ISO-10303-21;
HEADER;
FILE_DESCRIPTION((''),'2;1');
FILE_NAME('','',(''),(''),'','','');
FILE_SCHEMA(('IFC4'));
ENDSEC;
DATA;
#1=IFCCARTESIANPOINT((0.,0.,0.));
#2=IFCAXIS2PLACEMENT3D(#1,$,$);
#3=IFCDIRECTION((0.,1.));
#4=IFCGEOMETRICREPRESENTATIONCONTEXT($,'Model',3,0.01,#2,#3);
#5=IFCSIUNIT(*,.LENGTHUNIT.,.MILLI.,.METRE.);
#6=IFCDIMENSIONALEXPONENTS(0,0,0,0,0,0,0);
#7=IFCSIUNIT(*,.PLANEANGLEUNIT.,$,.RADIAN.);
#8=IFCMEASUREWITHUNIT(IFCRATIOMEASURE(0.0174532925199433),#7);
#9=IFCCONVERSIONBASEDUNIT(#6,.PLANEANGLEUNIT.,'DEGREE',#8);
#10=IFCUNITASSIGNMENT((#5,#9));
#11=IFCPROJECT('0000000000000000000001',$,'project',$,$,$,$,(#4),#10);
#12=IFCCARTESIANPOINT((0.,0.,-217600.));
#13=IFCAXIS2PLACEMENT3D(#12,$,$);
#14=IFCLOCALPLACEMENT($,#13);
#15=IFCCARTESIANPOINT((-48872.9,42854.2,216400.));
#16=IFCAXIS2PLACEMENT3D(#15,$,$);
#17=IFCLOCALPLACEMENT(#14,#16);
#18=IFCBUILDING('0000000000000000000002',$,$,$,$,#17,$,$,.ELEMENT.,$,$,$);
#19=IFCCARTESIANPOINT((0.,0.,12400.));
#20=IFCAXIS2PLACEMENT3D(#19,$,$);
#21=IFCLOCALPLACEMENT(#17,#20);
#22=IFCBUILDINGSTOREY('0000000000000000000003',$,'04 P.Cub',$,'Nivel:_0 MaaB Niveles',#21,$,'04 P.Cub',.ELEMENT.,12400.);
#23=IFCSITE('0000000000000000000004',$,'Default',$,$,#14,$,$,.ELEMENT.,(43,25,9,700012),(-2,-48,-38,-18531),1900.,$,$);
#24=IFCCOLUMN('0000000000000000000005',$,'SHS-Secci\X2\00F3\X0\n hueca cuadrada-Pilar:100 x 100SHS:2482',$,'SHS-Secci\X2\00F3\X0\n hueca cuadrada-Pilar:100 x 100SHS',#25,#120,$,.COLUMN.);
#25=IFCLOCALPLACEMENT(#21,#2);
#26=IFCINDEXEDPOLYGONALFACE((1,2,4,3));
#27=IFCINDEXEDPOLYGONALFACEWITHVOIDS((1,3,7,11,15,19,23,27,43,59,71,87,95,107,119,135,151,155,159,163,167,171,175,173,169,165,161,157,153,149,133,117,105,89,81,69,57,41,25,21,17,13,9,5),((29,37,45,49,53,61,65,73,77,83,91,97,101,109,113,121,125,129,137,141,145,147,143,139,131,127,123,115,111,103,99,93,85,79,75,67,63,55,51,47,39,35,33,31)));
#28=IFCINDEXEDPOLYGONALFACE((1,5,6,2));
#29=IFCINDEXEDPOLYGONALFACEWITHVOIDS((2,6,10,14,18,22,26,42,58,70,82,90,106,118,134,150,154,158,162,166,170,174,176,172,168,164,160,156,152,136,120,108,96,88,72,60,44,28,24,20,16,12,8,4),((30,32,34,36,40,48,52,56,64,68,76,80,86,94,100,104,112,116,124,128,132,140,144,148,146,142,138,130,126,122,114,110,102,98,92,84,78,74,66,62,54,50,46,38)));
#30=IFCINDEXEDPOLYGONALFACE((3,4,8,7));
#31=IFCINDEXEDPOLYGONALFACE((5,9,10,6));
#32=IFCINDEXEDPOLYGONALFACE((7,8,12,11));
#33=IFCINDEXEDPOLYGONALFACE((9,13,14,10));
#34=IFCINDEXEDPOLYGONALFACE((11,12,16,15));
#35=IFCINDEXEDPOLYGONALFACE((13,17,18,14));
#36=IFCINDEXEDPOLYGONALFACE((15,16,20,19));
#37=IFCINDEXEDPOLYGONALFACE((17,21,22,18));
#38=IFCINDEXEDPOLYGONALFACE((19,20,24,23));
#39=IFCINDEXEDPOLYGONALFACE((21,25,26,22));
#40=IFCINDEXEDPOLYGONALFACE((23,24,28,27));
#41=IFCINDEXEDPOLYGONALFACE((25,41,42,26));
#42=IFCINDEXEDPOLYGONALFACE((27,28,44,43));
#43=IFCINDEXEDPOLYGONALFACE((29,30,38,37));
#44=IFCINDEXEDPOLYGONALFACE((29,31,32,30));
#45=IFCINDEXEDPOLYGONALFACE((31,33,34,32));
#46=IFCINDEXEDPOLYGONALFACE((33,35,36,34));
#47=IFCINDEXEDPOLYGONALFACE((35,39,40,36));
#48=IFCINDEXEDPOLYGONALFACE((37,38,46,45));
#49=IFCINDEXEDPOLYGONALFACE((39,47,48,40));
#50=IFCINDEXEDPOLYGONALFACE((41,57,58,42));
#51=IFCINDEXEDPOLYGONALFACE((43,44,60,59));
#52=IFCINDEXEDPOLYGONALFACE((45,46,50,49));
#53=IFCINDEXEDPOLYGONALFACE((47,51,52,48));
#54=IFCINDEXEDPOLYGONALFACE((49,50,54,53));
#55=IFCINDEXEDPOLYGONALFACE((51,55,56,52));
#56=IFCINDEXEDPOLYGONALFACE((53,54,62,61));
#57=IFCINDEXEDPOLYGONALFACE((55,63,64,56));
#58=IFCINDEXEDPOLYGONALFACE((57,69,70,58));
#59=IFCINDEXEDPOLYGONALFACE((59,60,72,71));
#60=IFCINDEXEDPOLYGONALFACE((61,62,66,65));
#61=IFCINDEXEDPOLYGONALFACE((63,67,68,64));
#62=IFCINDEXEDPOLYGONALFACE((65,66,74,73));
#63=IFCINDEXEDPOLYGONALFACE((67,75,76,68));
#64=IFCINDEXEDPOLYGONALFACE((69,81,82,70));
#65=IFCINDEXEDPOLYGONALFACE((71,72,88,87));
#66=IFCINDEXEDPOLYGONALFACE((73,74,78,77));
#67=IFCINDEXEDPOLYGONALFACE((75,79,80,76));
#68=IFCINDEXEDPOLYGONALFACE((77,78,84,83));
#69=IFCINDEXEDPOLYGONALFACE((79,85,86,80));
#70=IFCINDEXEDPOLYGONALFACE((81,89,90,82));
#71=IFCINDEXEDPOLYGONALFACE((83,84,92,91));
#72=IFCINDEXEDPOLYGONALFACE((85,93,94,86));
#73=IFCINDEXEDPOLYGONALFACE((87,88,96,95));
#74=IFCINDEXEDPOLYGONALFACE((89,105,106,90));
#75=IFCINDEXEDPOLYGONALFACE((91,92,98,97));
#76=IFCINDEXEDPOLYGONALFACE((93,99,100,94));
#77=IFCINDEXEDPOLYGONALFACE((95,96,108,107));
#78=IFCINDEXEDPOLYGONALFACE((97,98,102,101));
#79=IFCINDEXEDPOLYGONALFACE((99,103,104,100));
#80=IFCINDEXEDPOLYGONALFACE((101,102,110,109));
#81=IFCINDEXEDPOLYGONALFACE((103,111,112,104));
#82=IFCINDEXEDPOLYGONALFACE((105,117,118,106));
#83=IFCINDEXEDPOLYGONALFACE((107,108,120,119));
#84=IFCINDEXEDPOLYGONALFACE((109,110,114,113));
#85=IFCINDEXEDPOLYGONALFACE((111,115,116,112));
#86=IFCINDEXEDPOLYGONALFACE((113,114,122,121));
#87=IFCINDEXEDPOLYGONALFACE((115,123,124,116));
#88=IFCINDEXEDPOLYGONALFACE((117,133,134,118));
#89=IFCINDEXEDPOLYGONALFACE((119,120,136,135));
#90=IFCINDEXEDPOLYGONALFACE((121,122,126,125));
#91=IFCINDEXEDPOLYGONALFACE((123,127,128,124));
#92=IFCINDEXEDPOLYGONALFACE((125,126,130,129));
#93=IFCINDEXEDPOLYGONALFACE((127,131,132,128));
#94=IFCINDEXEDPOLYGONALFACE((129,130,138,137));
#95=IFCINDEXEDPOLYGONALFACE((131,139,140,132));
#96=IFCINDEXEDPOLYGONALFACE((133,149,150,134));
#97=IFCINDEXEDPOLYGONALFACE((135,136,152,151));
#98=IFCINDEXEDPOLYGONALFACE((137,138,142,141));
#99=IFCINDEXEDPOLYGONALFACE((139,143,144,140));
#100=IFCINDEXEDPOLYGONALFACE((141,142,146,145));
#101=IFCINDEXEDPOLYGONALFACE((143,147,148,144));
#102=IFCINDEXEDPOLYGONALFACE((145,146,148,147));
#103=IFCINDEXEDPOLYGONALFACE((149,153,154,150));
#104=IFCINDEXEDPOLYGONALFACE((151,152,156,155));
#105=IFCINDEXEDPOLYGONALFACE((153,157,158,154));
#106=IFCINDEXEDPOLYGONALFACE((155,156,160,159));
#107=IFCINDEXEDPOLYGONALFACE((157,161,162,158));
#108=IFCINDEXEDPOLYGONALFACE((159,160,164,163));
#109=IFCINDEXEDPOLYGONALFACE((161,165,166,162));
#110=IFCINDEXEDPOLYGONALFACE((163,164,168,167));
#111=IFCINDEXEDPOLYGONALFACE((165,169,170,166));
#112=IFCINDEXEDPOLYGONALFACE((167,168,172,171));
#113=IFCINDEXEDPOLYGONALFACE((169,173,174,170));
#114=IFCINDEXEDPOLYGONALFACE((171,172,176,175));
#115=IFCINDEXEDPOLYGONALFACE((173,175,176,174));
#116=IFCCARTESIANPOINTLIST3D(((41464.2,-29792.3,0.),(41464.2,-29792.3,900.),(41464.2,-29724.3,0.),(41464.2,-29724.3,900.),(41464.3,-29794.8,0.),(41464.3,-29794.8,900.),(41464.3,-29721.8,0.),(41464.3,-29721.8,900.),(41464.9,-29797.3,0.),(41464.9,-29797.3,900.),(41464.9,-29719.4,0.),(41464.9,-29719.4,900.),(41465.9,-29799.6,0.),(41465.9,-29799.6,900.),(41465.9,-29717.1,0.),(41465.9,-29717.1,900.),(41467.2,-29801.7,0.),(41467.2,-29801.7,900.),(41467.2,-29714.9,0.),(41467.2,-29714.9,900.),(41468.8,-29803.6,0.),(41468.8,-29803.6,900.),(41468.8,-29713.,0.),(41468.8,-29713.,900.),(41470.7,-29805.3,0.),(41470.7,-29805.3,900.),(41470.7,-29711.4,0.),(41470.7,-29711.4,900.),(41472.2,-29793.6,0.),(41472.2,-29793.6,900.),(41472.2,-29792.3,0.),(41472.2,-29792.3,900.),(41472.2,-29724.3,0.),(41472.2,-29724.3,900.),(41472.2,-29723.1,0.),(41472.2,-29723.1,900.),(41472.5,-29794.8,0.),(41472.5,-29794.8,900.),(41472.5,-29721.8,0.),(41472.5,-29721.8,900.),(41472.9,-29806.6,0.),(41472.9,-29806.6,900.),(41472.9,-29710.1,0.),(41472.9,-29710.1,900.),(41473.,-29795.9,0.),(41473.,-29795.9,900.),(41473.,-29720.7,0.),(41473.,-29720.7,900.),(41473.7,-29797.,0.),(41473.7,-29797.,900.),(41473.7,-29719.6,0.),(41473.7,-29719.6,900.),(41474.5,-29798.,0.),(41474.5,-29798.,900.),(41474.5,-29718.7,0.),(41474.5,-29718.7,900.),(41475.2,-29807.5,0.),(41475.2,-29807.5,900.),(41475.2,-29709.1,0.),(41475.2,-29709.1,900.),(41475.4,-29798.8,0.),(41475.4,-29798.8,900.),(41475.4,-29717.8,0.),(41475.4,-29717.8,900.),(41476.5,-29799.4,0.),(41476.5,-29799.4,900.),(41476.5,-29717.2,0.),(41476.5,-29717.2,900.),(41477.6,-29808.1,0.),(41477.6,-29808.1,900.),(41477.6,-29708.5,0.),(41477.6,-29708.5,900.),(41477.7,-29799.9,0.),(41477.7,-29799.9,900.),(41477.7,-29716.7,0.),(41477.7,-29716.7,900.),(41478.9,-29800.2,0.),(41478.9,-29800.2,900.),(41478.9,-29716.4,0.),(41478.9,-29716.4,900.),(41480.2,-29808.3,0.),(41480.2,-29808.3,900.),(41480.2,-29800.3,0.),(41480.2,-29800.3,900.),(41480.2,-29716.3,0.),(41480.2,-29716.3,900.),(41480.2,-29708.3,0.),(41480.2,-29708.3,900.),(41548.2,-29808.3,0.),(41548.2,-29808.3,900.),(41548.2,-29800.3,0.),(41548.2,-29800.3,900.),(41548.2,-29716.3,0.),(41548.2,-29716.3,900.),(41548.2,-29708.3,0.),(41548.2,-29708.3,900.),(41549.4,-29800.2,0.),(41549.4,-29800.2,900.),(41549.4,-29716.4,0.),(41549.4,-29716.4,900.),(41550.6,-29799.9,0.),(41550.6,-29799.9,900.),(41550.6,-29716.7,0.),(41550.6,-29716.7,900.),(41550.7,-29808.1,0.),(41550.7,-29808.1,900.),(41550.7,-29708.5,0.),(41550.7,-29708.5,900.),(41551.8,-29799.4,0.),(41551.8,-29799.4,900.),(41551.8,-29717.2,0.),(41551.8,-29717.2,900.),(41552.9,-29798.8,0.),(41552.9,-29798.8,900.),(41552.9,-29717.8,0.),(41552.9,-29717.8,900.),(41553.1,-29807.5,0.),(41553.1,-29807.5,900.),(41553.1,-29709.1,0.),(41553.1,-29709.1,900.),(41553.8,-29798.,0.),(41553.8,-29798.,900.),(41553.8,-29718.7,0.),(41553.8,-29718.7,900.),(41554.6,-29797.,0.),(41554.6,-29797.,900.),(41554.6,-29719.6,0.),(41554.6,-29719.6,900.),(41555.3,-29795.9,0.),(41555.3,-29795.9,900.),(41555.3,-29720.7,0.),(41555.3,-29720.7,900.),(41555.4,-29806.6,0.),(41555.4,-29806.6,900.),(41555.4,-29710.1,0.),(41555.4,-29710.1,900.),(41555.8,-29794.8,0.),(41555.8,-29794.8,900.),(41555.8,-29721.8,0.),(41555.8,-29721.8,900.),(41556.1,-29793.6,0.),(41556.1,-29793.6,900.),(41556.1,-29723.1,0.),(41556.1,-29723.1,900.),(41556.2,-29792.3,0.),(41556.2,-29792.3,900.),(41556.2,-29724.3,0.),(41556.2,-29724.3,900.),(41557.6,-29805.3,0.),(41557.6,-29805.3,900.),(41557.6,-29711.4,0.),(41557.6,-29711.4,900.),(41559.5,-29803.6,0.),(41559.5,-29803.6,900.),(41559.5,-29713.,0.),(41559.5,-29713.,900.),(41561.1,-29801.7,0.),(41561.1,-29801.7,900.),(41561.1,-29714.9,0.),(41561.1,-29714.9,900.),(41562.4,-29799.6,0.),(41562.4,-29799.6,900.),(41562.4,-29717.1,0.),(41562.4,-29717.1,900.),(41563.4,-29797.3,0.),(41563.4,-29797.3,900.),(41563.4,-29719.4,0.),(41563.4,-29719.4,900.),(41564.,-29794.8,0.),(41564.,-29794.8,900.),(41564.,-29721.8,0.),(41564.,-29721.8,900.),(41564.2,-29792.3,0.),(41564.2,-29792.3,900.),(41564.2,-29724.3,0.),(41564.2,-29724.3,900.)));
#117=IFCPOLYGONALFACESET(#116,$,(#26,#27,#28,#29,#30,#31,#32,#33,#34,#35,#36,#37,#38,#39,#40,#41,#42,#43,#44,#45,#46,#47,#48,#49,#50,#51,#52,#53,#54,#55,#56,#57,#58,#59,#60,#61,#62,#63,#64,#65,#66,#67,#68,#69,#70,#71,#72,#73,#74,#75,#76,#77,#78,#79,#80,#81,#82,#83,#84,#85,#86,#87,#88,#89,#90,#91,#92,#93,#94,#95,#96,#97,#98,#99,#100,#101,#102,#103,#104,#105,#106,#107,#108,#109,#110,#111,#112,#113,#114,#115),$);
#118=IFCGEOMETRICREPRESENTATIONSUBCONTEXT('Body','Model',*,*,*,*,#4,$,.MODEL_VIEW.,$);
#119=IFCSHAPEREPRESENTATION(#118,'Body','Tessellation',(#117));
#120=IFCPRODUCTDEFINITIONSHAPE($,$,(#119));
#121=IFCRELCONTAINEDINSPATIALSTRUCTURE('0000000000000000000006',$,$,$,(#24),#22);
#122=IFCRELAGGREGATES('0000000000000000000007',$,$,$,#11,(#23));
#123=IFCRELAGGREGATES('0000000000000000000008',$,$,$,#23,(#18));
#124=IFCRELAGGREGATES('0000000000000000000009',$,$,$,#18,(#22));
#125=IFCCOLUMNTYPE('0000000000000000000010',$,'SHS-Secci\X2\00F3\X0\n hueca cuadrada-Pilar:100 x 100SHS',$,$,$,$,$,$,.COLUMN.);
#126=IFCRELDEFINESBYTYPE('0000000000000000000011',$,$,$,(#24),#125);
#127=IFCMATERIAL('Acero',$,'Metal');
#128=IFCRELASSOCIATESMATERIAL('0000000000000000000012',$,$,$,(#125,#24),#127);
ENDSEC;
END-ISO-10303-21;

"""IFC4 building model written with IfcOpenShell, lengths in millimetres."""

from ifc_helpers import new_model, entity, si_unit, converted_unit, direction, frame, origin, place, context, subcontext, project, spatial, indexed_curve, outline, extrude, source, transform, mapped, material, type_object, type_shapes, element, save


model = new_model("IFC4")

# Units and contexts
model_context = context("Model", 3, precision=0.01, world=origin(), true_north=direction((0.0, 1.0)))
body_context = subcontext(model_context, "Body", "Model", "MODEL_VIEW")
ifc_project = project(units=[si_unit("LENGTHUNIT", "METRE", prefix="MILLI"), converted_unit("PLANEANGLEUNIT", "DEGREE", entity("IfcRatioMeasure", 0.0174532925199433), si_unit("PLANEANGLEUNIT", "RADIAN"), dimensions=[0, 0, 0, 0, 0, 0, 0])], contexts=[model_context])

# Site, building, storey
site_placement = place(None, frame((0.0, 0.0, -217600.0)))
site = spatial("IfcSite", under=ifc_project, at=site_placement, Name="Default", CompositionType="ELEMENT", RefLatitude=(43, 25, 9, 700012), RefLongitude=(-2, -48, -38, -18531), RefElevation=1900.0)
building_placement = place(site_placement, frame((-48872.9, 42854.2, 216400.0)))
building = spatial("IfcBuilding", under=site, at=building_placement, CompositionType="ELEMENT")
storey_placement = place(building_placement, frame((0.0, 0.0, 12400.0)))
storey = spatial("IfcBuildingStorey", under=building, at=storey_placement, Name="04 P.Cub", ObjectType="Nivel:_0 MaaB Niveles", LongName="04 P.Cub", CompositionType="ELEMENT", Elevation=12400.0)

# Column
ifc_material_1 = material(Name="Acero", Category="Metal")
column_type_1 = type_object("IfcColumnType", Name="SHS-Sección hueca cuadrada-Pilar:100 x 100SHS", PredefinedType="COLUMN", material=ifc_material_1)
shared_shape_1 = source(origin(), body_context, "Body", "SweptSolid", [
    extrude(outline(indexed_curve([(-34.0, -50.0), (34.0, -50.0), (36.5, -49.8), (38.9, -49.2), (41.3, -48.3), (43.4, -46.9), (45.3, -45.3), (46.9, -43.4), (48.3, -41.3), (49.2, -38.9), (49.8, -36.5), (50.0, -34.0), (50.0, 34.0), (49.8, 36.5), (49.2, 38.9), (48.3, 41.3), (46.9, 43.4), (45.3, 45.3), (43.4, 46.9), (41.3, 48.3), (38.9, 49.2), (36.5, 49.8), (34.0, 50.0), (-34.0, 50.0), (-36.5, 49.8), (-38.9, 49.2), (-41.3, 48.3), (-43.4, 46.9), (-45.3, 45.3), (-46.9, 43.4), (-48.3, 41.3), (-49.2, 38.9), (-49.8, 36.5), (-50.0, 34.0), (-50.0, -34.0), (-49.8, -36.5), (-49.2, -38.9), (-48.3, -41.3), (-46.9, -43.4), (-45.3, -45.3), (-43.4, -46.9), (-41.3, -48.3), (-38.9, -49.2), (-36.5, -49.8), (-34.0, -50.0)], self_intersect=False), holes=[indexed_curve([(-42.0, 34.0), (-41.9, 35.3), (-41.6, 36.5), (-41.1, 37.6), (-40.5, 38.7), (-39.7, 39.7), (-38.7, 40.5), (-37.6, 41.1), (-36.5, 41.6), (-35.3, 41.9), (-34.0, 42.0), (34.0, 42.0), (35.3, 41.9), (36.5, 41.6), (37.6, 41.1), (38.7, 40.5), (39.7, 39.7), (40.5, 38.7), (41.1, 37.6), (41.6, 36.5), (41.9, 35.3), (42.0, 34.0), (42.0, -34.0), (41.9, -35.3), (41.6, -36.5), (41.1, -37.6), (40.5, -38.7), (39.7, -39.7), (38.7, -40.5), (37.6, -41.1), (36.5, -41.6), (35.3, -41.9), (34.0, -42.0), (-34.0, -42.0), (-35.3, -41.9), (-36.5, -41.6), (-37.6, -41.1), (-38.7, -40.5), (-39.7, -39.7), (-40.5, -38.7), (-41.1, -37.6), (-41.6, -36.5), (-41.9, -35.3), (-42.0, -34.0), (-42.0, 34.0)], self_intersect=False)]), frame((0.0, 0.0, 12400.0), z_axis=(0.0, 0.0, 1.0), x_axis=(0.0, 1.0, 0.0)), (0.0, 0.0, 1.0), 900.0),
])
type_shapes(column_type_1, [shared_shape_1])
column_1_placement = place(storey_placement, frame((41514.2, -29758.3, -12400.0), z_axis=(0.0, 0.0, 1.0), x_axis=(0.0, -1.0, 0.0)))
element("IfcColumn", 1, at=column_1_placement, inside=storey, type_object=column_type_1, material=ifc_material_1, Name="SHS-Sección hueca cuadrada-Pilar:100 x 100SHS:2482", ObjectType="SHS-Sección hueca cuadrada-Pilar:100 x 100SHS", PredefinedType="COLUMN", context=body_context, shape_type="MappedRepresentation", body=[
    mapped(shared_shape_1, transform((0.0, 0.0, 0.0), scale=1.0)),
])

save(model, "model.ifc")
